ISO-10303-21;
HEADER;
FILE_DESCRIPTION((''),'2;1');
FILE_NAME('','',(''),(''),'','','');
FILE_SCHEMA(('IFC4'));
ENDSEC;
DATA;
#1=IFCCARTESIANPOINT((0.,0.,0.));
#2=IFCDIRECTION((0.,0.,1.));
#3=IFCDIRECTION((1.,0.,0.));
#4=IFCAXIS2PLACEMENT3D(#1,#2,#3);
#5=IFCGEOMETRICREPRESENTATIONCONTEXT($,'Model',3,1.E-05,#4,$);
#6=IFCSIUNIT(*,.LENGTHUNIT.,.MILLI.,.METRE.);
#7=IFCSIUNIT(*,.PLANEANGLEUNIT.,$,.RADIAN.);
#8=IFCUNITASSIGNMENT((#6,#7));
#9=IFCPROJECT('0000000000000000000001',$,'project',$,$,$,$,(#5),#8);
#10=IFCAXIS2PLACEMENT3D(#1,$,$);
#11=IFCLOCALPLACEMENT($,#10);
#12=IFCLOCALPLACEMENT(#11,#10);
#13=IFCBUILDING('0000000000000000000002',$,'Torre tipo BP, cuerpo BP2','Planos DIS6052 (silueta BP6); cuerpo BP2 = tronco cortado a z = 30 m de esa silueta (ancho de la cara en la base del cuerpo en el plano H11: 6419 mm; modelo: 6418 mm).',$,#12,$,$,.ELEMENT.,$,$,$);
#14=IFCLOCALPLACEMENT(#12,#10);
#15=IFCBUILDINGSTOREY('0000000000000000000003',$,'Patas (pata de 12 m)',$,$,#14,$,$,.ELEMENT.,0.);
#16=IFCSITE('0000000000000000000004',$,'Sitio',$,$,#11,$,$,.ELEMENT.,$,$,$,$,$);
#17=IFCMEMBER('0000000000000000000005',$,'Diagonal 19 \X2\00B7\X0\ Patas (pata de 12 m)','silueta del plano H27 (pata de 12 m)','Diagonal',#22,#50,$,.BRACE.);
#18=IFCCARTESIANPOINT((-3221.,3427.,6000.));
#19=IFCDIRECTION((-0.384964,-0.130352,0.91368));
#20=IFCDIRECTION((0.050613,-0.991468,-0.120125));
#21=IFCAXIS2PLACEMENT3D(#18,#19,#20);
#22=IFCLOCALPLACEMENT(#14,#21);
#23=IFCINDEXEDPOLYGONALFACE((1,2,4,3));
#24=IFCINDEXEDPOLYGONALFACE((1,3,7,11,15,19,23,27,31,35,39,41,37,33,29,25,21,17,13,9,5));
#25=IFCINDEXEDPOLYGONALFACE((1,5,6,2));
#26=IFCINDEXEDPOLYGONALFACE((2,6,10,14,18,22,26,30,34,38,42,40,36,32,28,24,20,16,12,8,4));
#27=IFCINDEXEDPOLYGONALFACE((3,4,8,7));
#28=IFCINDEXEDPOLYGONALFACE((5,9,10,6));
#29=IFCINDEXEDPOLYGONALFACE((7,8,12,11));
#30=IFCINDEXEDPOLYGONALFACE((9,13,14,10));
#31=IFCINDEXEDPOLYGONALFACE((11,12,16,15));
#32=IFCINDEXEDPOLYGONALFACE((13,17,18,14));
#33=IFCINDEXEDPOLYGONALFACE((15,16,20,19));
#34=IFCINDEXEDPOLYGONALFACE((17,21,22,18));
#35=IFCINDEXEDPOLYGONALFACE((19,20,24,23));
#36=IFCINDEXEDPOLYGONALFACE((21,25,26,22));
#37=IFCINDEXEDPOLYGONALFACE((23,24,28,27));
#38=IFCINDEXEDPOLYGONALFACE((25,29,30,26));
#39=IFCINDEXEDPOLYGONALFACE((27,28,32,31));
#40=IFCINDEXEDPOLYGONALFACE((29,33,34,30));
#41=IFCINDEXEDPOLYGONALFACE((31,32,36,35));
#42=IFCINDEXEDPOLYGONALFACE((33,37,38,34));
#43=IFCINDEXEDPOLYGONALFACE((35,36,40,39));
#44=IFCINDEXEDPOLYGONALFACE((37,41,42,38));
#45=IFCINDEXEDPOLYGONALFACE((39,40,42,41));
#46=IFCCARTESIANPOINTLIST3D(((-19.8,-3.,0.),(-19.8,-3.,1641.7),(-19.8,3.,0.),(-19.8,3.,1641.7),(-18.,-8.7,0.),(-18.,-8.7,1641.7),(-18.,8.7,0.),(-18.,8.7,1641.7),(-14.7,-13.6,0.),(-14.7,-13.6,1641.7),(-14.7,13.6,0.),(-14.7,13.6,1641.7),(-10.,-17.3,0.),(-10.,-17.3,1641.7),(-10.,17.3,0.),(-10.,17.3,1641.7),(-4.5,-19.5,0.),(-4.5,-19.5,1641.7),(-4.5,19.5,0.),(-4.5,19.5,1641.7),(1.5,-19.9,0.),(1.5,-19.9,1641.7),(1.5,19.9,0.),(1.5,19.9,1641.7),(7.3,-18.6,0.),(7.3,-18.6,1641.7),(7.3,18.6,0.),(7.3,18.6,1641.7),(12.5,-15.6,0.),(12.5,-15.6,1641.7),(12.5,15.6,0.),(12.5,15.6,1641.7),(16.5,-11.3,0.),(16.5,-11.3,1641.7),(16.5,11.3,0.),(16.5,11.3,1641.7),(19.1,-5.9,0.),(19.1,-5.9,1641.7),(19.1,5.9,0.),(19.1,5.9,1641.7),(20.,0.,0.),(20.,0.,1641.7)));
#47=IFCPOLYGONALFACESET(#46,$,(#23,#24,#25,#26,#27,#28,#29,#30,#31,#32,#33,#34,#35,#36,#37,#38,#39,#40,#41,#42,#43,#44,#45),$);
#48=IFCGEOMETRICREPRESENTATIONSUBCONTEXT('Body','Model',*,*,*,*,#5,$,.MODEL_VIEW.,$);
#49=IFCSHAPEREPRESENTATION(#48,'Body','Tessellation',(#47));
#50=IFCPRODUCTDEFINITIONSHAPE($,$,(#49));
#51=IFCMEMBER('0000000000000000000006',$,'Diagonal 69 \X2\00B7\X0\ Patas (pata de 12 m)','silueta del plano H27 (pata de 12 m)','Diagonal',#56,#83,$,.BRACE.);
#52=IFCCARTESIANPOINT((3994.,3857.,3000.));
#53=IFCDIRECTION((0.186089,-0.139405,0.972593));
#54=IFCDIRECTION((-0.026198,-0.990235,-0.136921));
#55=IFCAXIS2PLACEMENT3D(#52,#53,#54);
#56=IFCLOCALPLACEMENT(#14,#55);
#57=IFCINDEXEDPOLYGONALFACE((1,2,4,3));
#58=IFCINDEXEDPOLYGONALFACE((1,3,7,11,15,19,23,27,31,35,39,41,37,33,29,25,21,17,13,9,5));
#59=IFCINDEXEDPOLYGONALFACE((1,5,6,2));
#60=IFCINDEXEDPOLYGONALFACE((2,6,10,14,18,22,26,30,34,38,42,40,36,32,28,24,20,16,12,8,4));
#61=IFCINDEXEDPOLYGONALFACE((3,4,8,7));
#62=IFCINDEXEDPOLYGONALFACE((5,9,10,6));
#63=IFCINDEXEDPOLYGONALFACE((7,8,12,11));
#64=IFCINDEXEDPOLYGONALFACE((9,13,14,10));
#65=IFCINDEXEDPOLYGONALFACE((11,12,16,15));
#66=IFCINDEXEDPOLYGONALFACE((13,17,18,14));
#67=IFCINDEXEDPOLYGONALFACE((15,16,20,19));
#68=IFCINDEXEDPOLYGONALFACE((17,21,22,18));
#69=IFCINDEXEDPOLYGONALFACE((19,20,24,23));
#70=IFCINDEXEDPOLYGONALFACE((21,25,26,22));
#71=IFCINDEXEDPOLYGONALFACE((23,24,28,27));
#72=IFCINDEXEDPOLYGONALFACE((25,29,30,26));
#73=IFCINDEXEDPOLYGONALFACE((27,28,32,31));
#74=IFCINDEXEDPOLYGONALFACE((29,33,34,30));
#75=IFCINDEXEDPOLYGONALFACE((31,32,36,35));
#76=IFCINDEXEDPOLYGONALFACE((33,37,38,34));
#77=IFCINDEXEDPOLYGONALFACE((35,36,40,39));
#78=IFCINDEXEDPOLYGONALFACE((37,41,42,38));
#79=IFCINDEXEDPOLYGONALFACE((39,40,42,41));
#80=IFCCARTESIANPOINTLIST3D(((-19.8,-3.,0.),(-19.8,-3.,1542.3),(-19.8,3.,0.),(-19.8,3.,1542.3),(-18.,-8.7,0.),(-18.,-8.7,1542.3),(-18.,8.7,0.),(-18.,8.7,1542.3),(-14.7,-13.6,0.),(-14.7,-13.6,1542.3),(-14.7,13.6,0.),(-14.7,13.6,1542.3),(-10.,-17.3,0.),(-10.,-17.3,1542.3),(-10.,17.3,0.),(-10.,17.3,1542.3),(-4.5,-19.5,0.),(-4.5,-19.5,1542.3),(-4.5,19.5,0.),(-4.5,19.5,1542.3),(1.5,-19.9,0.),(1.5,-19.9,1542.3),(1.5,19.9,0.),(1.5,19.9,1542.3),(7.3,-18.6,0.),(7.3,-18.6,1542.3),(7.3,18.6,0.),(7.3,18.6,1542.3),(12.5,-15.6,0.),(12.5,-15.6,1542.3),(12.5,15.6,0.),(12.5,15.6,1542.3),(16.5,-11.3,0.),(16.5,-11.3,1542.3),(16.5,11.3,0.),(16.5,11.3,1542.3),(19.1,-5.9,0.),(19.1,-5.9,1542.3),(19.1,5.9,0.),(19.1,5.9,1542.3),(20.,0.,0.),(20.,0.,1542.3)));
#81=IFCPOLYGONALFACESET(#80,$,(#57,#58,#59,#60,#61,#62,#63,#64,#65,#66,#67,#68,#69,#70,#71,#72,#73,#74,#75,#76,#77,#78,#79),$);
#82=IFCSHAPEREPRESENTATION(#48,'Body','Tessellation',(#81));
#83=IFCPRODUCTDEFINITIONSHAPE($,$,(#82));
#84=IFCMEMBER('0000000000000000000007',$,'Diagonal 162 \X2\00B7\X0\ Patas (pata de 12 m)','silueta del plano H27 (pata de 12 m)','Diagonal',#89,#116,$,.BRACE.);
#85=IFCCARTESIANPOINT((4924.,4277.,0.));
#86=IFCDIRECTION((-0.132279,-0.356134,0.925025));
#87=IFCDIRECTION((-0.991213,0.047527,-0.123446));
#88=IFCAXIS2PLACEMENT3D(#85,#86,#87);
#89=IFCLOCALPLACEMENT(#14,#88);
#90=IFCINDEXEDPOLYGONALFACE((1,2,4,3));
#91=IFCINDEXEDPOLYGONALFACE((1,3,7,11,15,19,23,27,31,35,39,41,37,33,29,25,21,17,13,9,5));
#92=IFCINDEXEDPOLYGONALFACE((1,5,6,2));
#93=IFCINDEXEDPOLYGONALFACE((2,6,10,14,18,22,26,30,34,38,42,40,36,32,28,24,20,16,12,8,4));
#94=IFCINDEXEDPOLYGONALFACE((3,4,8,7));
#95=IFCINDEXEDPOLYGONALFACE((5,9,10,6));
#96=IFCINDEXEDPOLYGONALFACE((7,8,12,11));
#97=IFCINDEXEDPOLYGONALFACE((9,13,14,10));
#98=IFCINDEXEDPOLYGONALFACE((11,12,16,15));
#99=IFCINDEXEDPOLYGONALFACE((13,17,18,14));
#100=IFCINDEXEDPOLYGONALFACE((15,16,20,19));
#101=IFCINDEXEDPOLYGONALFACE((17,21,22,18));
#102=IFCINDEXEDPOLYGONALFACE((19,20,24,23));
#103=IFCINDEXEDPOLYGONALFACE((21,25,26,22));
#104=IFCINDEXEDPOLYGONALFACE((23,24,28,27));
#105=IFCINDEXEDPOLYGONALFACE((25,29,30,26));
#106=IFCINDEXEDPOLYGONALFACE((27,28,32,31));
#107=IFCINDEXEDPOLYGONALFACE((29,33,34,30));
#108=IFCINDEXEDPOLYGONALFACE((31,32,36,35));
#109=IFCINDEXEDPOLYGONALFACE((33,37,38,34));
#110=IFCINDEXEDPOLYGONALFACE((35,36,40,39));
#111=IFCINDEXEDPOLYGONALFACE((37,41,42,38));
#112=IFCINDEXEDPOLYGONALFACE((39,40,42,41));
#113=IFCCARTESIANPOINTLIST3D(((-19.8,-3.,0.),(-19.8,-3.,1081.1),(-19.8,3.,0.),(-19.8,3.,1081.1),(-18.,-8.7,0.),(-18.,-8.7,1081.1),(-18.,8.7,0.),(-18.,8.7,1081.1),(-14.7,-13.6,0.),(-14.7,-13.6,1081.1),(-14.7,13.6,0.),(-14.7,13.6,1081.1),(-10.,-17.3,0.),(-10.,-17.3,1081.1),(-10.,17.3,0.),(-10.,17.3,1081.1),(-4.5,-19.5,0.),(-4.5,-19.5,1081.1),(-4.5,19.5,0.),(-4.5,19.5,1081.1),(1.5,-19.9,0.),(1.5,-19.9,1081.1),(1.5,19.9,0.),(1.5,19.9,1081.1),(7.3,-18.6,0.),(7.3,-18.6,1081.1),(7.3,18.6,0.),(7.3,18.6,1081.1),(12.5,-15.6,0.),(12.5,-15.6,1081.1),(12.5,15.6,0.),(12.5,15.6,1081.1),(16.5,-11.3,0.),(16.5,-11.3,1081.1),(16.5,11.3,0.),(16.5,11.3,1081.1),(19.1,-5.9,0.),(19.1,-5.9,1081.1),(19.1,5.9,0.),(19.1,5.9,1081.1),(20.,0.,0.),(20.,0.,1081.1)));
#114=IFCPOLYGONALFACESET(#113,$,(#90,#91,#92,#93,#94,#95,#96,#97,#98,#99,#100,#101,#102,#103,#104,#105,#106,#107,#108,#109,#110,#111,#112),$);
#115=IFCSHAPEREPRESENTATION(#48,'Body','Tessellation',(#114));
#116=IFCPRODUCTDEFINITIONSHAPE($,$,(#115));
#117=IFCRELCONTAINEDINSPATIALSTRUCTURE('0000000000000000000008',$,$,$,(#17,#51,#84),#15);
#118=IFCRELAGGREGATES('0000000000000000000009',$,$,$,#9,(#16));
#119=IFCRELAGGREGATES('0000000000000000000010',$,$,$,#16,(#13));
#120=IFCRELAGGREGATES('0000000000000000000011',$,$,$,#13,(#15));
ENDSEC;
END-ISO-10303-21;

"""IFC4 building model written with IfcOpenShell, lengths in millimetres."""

from ifc_helpers import new_model, si_unit, frame, origin, origin_with_axes, place, context, subcontext, project, spatial, circle, extrude, element, save


model = new_model("IFC4")

# Units and contexts
model_context = context("Model", 3, precision=1e-05, world=origin_with_axes())
body_context = subcontext(model_context, "Body", "Model", "MODEL_VIEW")
ifc_project = project(units=[si_unit("LENGTHUNIT", "METRE", prefix="MILLI"), si_unit("PLANEANGLEUNIT", "RADIAN")], contexts=[model_context])

# Site, building, storey
site_placement = place(None, origin())
site = spatial("IfcSite", under=ifc_project, at=site_placement, Name="Sitio", CompositionType="ELEMENT")
building_placement = place(site_placement, origin())
building = spatial("IfcBuilding", under=site, at=building_placement, Name="Torre tipo BP, cuerpo BP2", Description="Planos DIS6052 (silueta BP6); cuerpo BP2 = tronco cortado a z = 30 m de esa silueta (ancho de la cara en la base del cuerpo en el plano H11: 6419 mm; modelo: 6418 mm).", CompositionType="ELEMENT")
storey_placement = place(building_placement, origin())
storey = spatial("IfcBuildingStorey", under=building, at=storey_placement, Name="Patas (pata de 12 m)", CompositionType="ELEMENT", Elevation=0.0)

# Members
member_1_placement = place(storey_placement, frame((-3221.0, 3427.0, 6000.0), z_axis=(-0.384964, -0.130352, 0.91368), x_axis=(0.050613, -0.991468, -0.120125)))
element("IfcMember", 1, at=member_1_placement, inside=storey, Name="Diagonal 19 · Patas (pata de 12 m)", Description="silueta del plano H27 (pata de 12 m)", ObjectType="Diagonal", PredefinedType="BRACE", context=body_context, shape_type="SweptSolid", body=[
    extrude(circle(Radius=20.0), None, (0.0, 0.0, 1.0), 1641.7),
])
member_2_placement = place(storey_placement, frame((3994.0, 3857.0, 3000.0), z_axis=(0.186089, -0.139405, 0.972593), x_axis=(-0.026198, -0.990235, -0.136921)))
element("IfcMember", 2, at=member_2_placement, inside=storey, Name="Diagonal 69 · Patas (pata de 12 m)", Description="silueta del plano H27 (pata de 12 m)", ObjectType="Diagonal", PredefinedType="BRACE", context=body_context, shape_type="SweptSolid", body=[
    extrude(circle(Radius=20.0), None, (0.0, 0.0, 1.0), 1542.3),
])
member_3_placement = place(storey_placement, frame((4924.0, 4277.0, 0.0), z_axis=(-0.132279, -0.356134, 0.925025), x_axis=(-0.991213, 0.047527, -0.123446)))
element("IfcMember", 3, at=member_3_placement, inside=storey, Name="Diagonal 162 · Patas (pata de 12 m)", Description="silueta del plano H27 (pata de 12 m)", ObjectType="Diagonal", PredefinedType="BRACE", context=body_context, shape_type="SweptSolid", body=[
    extrude(circle(Radius=20.0), None, (0.0, 0.0, 1.0), 1081.1),
])

save(model, "model.ifc")
